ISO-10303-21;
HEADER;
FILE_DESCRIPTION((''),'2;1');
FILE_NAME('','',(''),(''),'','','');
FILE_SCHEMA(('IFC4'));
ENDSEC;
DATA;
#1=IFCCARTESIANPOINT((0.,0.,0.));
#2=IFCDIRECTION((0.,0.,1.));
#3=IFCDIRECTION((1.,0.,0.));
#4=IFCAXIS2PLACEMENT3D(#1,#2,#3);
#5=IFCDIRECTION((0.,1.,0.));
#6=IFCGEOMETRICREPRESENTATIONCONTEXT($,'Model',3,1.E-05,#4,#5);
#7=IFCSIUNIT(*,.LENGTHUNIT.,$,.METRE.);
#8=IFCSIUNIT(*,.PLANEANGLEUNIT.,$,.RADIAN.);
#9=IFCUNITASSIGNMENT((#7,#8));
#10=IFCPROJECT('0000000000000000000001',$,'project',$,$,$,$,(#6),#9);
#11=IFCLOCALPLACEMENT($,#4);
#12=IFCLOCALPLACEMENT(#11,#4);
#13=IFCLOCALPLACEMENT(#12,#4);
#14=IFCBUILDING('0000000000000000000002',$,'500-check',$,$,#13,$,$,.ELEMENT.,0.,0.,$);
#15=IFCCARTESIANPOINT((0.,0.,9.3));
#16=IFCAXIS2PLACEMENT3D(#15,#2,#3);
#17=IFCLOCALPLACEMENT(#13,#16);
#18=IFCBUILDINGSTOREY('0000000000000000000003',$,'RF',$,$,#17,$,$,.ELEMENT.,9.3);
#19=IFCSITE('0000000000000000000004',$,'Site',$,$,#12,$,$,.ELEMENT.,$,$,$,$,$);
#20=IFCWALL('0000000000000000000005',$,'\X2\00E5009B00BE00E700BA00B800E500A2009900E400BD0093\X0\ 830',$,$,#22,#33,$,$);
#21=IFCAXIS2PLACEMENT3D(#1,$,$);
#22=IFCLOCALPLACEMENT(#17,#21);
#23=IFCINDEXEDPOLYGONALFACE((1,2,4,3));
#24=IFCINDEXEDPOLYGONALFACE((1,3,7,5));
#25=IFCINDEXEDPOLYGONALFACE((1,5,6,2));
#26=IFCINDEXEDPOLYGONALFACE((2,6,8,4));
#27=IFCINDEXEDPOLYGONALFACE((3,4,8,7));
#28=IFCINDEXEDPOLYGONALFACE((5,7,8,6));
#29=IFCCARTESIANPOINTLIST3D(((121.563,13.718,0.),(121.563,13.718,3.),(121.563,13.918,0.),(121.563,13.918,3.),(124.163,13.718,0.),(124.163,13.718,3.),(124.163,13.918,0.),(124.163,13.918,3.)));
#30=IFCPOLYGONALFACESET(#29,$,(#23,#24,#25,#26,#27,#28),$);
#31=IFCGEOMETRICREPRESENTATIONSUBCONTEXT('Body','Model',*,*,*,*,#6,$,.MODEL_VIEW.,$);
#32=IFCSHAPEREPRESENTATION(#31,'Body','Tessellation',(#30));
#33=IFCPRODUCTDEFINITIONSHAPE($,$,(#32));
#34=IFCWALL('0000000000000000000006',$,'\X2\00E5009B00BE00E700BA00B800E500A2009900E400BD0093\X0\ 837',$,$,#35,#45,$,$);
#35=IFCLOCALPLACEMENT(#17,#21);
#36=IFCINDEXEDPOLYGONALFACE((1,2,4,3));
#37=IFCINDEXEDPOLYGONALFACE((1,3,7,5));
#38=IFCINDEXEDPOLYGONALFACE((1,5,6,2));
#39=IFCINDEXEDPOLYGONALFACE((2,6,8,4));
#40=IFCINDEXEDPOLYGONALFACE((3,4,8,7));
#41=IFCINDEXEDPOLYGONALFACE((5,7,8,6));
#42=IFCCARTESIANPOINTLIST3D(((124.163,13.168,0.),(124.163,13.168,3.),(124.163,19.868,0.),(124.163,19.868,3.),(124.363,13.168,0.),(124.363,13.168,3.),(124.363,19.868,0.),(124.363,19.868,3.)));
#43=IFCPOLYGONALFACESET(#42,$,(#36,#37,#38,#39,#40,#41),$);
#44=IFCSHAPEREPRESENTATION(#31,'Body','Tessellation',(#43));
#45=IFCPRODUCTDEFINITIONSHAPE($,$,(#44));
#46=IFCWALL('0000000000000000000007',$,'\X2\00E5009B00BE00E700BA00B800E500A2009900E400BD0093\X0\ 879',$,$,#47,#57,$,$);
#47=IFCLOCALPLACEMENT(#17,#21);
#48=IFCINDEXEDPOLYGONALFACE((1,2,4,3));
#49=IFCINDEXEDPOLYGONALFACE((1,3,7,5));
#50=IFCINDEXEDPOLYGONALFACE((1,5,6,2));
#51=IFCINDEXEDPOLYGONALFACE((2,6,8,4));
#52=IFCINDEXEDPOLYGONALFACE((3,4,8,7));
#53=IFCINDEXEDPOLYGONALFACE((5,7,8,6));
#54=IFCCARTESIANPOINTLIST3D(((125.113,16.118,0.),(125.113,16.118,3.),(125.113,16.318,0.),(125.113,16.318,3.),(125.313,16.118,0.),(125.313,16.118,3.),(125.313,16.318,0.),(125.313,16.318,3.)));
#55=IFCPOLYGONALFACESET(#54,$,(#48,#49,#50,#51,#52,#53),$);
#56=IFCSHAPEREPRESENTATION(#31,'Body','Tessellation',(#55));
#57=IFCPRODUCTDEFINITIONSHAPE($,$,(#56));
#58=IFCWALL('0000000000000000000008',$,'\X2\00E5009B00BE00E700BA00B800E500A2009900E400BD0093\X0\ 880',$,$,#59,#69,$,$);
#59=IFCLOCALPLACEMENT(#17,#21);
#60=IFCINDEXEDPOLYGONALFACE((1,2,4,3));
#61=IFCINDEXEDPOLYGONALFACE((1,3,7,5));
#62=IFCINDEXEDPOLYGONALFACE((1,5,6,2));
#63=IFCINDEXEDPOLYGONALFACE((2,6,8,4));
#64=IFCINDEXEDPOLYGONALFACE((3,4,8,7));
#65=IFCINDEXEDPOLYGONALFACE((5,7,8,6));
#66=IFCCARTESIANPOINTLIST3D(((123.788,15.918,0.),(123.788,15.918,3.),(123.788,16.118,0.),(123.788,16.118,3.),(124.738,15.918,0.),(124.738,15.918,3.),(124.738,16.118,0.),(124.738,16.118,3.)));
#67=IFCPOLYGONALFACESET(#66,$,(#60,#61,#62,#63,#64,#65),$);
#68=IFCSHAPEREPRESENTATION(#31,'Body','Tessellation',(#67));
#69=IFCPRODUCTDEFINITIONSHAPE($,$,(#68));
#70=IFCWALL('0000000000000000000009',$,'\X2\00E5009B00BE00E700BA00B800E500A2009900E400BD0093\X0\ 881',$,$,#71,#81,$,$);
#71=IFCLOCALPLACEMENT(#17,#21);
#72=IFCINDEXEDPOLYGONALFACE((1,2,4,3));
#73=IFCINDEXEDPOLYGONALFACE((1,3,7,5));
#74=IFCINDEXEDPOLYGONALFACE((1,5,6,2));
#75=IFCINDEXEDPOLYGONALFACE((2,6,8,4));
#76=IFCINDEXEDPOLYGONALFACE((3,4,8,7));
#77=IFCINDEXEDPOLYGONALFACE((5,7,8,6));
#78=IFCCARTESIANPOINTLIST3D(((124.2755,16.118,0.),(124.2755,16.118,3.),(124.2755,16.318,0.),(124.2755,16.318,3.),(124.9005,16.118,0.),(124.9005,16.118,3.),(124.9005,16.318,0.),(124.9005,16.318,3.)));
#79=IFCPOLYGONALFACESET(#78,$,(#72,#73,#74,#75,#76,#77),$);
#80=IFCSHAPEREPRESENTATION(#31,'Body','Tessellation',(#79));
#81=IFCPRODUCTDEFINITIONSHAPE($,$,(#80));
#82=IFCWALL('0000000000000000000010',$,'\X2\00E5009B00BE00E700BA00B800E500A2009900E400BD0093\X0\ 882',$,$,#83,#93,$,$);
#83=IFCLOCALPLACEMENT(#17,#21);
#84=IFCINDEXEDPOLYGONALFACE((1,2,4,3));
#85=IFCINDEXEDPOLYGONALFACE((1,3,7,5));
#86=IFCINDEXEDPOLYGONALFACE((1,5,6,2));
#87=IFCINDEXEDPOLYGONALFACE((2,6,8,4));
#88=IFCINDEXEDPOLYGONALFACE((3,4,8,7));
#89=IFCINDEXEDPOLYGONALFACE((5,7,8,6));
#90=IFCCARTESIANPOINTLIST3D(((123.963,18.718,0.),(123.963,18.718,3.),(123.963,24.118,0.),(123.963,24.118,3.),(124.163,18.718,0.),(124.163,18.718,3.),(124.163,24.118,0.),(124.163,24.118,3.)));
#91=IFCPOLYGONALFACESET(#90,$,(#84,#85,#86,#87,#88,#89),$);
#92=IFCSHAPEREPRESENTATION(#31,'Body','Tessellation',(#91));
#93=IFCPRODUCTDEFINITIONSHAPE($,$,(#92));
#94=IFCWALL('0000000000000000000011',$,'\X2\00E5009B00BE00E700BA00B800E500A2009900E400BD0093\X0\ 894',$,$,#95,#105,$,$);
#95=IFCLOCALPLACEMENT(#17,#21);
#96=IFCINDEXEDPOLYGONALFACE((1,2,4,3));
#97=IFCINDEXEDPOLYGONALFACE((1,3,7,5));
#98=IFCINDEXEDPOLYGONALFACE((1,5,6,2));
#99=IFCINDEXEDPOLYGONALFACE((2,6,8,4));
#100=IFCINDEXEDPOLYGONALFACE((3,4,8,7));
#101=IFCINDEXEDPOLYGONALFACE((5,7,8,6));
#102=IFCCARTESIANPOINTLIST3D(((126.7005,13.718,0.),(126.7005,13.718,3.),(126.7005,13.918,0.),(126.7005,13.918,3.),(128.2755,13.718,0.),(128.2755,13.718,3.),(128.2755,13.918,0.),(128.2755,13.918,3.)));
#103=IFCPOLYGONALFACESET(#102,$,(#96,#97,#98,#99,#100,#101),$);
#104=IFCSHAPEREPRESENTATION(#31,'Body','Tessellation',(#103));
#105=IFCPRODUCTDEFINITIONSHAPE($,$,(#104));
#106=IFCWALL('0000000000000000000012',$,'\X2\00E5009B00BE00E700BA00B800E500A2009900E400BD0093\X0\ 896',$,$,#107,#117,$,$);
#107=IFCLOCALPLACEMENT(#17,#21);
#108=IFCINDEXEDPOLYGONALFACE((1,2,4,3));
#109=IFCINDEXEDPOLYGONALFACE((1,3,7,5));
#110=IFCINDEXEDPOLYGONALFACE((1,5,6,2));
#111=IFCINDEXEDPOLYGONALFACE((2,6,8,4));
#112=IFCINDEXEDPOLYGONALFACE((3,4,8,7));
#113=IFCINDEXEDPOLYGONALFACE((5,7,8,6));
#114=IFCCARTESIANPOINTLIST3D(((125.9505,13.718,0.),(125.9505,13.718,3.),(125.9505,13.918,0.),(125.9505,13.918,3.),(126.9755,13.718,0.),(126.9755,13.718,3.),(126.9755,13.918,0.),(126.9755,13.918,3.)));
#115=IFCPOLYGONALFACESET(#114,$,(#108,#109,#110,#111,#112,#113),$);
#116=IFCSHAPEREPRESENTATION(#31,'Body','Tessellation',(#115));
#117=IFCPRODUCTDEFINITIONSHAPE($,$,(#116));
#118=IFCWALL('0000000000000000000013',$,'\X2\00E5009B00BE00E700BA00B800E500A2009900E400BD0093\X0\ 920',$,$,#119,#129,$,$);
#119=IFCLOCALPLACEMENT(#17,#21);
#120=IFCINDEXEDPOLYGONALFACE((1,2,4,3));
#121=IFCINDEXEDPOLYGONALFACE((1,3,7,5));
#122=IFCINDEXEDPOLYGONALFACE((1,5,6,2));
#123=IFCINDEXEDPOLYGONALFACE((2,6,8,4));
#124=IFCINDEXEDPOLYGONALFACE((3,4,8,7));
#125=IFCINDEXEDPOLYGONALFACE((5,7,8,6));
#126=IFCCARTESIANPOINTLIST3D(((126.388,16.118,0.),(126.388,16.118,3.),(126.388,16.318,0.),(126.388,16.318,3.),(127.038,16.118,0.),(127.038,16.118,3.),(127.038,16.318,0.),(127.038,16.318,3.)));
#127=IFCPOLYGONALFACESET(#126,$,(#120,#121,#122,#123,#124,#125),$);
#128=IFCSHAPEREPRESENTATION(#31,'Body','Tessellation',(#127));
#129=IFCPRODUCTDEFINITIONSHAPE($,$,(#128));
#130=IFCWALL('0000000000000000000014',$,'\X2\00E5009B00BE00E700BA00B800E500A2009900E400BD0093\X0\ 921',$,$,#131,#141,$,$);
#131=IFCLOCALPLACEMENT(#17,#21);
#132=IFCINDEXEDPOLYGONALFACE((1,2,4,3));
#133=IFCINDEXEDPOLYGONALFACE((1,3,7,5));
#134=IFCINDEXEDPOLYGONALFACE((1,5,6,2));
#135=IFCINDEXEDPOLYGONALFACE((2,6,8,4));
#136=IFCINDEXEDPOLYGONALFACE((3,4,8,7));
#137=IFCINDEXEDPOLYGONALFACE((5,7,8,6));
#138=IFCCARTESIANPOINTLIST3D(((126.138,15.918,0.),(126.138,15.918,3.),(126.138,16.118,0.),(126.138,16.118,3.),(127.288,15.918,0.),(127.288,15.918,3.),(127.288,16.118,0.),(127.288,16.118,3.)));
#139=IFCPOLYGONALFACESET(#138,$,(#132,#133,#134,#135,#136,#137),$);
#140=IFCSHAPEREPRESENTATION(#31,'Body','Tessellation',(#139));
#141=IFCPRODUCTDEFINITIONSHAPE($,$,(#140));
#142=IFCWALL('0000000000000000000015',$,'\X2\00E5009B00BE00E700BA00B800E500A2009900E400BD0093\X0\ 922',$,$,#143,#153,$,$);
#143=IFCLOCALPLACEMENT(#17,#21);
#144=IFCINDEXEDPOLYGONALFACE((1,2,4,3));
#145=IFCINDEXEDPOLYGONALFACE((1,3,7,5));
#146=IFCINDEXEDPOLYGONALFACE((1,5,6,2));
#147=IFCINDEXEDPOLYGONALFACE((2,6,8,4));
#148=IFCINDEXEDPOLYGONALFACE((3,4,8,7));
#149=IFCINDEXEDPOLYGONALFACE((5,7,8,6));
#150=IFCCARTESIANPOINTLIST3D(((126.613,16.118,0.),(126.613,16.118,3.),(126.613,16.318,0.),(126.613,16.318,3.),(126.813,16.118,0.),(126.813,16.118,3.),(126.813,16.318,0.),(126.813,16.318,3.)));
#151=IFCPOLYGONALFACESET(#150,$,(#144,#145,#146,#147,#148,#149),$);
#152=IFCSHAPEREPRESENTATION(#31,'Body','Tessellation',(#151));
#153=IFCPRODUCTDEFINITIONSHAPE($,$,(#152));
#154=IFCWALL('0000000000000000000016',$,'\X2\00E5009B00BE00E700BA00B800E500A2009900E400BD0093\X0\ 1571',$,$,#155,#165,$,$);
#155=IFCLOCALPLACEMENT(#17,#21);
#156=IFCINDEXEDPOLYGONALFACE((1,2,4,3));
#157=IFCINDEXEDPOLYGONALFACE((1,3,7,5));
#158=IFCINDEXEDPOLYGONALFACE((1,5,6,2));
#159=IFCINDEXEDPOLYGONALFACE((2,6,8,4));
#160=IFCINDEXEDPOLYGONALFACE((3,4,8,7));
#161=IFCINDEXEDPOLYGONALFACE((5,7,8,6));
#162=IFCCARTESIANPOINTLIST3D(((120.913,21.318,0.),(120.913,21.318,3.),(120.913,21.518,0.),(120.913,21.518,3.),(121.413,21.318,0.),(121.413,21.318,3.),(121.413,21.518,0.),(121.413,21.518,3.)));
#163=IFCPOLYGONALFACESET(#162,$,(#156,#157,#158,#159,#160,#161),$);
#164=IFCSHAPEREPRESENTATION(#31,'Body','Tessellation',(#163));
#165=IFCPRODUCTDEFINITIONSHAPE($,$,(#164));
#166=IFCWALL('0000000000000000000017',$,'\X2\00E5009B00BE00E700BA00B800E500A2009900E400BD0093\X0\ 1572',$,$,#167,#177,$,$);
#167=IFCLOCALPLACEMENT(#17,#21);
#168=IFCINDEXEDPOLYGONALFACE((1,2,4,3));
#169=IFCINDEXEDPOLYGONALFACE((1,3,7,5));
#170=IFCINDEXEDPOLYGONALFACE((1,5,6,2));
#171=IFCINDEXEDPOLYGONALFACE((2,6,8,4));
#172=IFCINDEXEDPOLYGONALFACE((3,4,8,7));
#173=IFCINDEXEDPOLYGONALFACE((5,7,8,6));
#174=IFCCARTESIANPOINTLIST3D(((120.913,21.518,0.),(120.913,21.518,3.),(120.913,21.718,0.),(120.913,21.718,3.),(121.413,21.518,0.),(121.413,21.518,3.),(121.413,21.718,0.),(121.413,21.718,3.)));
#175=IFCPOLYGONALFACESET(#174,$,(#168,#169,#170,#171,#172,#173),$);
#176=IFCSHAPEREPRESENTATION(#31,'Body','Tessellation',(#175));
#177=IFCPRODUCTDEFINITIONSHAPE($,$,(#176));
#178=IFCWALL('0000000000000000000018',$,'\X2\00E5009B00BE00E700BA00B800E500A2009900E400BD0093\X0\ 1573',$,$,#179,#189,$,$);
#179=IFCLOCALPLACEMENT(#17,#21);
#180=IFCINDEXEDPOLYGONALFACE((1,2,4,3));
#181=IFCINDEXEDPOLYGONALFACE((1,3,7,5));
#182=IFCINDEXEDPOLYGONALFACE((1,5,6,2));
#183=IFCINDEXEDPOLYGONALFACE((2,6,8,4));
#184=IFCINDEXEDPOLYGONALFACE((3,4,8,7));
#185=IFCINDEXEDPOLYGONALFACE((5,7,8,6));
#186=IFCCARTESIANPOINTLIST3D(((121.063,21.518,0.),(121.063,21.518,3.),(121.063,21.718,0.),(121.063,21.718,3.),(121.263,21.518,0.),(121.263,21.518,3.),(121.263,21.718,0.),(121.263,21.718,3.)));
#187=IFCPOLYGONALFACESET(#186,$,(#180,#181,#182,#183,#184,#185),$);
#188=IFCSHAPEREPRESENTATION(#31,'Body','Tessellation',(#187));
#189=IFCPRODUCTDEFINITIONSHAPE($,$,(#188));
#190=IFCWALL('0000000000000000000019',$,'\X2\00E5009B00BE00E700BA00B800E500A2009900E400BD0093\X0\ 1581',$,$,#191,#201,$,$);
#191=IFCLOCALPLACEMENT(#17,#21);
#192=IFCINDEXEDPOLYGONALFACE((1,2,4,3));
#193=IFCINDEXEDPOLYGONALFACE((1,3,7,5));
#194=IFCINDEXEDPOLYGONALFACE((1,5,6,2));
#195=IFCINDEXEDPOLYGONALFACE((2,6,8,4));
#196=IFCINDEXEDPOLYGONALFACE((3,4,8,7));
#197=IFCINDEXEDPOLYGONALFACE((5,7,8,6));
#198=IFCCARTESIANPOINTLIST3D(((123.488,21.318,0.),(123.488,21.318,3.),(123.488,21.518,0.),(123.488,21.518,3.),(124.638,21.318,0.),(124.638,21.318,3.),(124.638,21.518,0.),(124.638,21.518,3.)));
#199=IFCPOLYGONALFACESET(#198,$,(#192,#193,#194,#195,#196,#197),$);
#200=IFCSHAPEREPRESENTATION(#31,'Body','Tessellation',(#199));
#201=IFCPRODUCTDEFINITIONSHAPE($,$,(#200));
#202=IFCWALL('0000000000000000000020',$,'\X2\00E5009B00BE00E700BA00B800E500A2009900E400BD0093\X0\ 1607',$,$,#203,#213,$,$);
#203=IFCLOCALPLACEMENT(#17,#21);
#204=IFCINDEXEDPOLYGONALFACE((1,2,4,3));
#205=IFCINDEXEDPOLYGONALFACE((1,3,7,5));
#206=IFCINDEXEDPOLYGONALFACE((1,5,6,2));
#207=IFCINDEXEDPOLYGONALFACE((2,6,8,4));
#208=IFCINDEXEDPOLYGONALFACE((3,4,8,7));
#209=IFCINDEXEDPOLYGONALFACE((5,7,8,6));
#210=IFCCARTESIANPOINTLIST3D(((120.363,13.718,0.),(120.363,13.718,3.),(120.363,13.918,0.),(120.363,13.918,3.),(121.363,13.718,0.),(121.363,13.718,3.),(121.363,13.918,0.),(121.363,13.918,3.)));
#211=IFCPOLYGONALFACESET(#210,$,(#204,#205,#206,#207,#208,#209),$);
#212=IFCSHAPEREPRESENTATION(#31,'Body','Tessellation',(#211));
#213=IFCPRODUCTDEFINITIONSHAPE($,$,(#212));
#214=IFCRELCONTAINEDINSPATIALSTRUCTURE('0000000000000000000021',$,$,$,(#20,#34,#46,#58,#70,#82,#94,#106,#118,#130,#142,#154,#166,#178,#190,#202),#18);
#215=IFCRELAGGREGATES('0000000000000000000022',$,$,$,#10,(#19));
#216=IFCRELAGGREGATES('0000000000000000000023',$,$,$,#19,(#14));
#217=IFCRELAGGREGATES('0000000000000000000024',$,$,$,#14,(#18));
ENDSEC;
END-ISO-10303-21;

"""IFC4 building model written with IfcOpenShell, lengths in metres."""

from ifc_helpers import new_model, si_unit, direction, frame, frame_2d, origin_with_axes, place, context, subcontext, project, spatial, rectangle, extrude, element, save


model = new_model("IFC4")

# Units and contexts
model_context = context("Model", 3, precision=1e-05, world=origin_with_axes(), true_north=direction((0.0, 1.0, 0.0)))
body_context = subcontext(model_context, "Body", "Model", "MODEL_VIEW")
ifc_project = project(units=[si_unit("LENGTHUNIT", "METRE"), si_unit("PLANEANGLEUNIT", "RADIAN")], contexts=[model_context])

# Site, building, storey
placement = place(None, origin_with_axes())
site_placement = place(placement, origin_with_axes())
site = spatial("IfcSite", under=ifc_project, at=site_placement, Name="Site", CompositionType="ELEMENT")
building_placement = place(site_placement, origin_with_axes())
building = spatial("IfcBuilding", under=site, at=building_placement, Name="500-check", CompositionType="ELEMENT", ElevationOfRefHeight=0.0, ElevationOfTerrain=0.0)
storey_placement = place(building_placement, frame((0.0, 0.0, 9.3), z_axis=(0.0, 0.0, 1.0), x_axis=(1.0, 0.0, 0.0)))
storey = spatial("IfcBuildingStorey", under=building, at=storey_placement, Name="RF", CompositionType="ELEMENT", Elevation=9.3)

# Walls
wall_1_placement = place(storey_placement, frame((122.863, 13.818, 0.0), z_axis=(0.0, 0.0, 1.0), x_axis=(1.0, 0.0, 0.0)))
element("IfcWall", 1, at=wall_1_placement, inside=storey, Name="å\u009b¾çº¸å¢\u0099ä½\u0093 830", context=body_context, shape_type="SweptSolid", body=[
    extrude(rectangle(XDim=2.6, YDim=0.2, at=frame_2d((0.0, 0.0), x_axis=(1.0, 0.0, 0.0))), frame((0.0, 0.0, 0.0), z_axis=(0.0, 0.0, 1.0)), (0.0, 0.0, 1.0), 3.0),
])
wall_2_placement = place(storey_placement, frame((124.263, 16.518, 0.0), z_axis=(0.0, 0.0, 1.0), x_axis=(0.0, 1.0, 0.0)))
element("IfcWall", 2, at=wall_2_placement, inside=storey, Name="å\u009b¾çº¸å¢\u0099ä½\u0093 837", context=body_context, shape_type="SweptSolid", body=[
    extrude(rectangle(XDim=6.7, YDim=0.2, at=frame_2d((0.0, 0.0), x_axis=(1.0, 0.0, 0.0))), frame((0.0, 0.0, 0.0), z_axis=(0.0, 0.0, 1.0)), (0.0, 0.0, 1.0), 3.0),
])
wall_3_placement = place(storey_placement, frame((125.213, 16.218, 0.0), z_axis=(0.0, 0.0, 1.0), x_axis=(0.0, -1.0, 0.0)))
element("IfcWall", 3, at=wall_3_placement, inside=storey, Name="å\u009b¾çº¸å¢\u0099ä½\u0093 879", context=body_context, shape_type="SweptSolid", body=[
    extrude(rectangle(XDim=0.2, YDim=0.2, at=frame_2d((0.0, 0.0), x_axis=(1.0, 0.0, 0.0))), frame((0.0, 0.0, 0.0), z_axis=(0.0, 0.0, 1.0)), (0.0, 0.0, 1.0), 3.0),
])
wall_4_placement = place(storey_placement, frame((124.263, 16.018, 0.0), z_axis=(0.0, 0.0, 1.0), x_axis=(1.0, 0.0, 0.0)))
element("IfcWall", 4, at=wall_4_placement, inside=storey, Name="å\u009b¾çº¸å¢\u0099ä½\u0093 880", context=body_context, shape_type="SweptSolid", body=[
    extrude(rectangle(XDim=0.95, YDim=0.2, at=frame_2d((0.0, 0.0), x_axis=(1.0, 0.0, 0.0))), frame((0.0, 0.0, 0.0), z_axis=(0.0, 0.0, 1.0)), (0.0, 0.0, 1.0), 3.0),
])
wall_5_placement = place(storey_placement, frame((124.588, 16.218, 0.0), z_axis=(0.0, 0.0, 1.0), x_axis=(1.0, 0.0, 0.0)))
element("IfcWall", 5, at=wall_5_placement, inside=storey, Name="å\u009b¾çº¸å¢\u0099ä½\u0093 881", context=body_context, shape_type="SweptSolid", body=[
    extrude(rectangle(XDim=0.625, YDim=0.2, at=frame_2d((0.0, 0.0), x_axis=(1.0, 0.0, 0.0))), frame((0.0, 0.0, 0.0), z_axis=(0.0, 0.0, 1.0)), (0.0, 0.0, 1.0), 3.0),
])
wall_6_placement = place(storey_placement, frame((124.063, 21.418, 0.0), z_axis=(0.0, 0.0, 1.0), x_axis=(0.0, -1.0, 0.0)))
element("IfcWall", 6, at=wall_6_placement, inside=storey, Name="å\u009b¾çº¸å¢\u0099ä½\u0093 882", context=body_context, shape_type="SweptSolid", body=[
    extrude(rectangle(XDim=5.4, YDim=0.2, at=frame_2d((0.0, 0.0), x_axis=(1.0, 0.0, 0.0))), frame((0.0, 0.0, 0.0), z_axis=(0.0, 0.0, 1.0)), (0.0, 0.0, 1.0), 3.0),
])
wall_7_placement = place(storey_placement, frame((127.488, 13.818, 0.0), z_axis=(0.0, 0.0, 1.0), x_axis=(1.0, 0.0, 0.0)))
element("IfcWall", 7, at=wall_7_placement, inside=storey, Name="å\u009b¾çº¸å¢\u0099ä½\u0093 894", context=body_context, shape_type="SweptSolid", body=[
    extrude(rectangle(XDim=1.575, YDim=0.2, at=frame_2d((0.0, 0.0), x_axis=(1.0, 0.0, 0.0))), frame((0.0, 0.0, 0.0), z_axis=(0.0, 0.0, 1.0)), (0.0, 0.0, 1.0), 3.0),
])
wall_8_placement = place(storey_placement, frame((126.463, 13.818, 0.0), z_axis=(0.0, 0.0, 1.0), x_axis=(1.0, 0.0, 0.0)))
element("IfcWall", 8, at=wall_8_placement, inside=storey, Name="å\u009b¾çº¸å¢\u0099ä½\u0093 896", context=body_context, shape_type="SweptSolid", body=[
    extrude(rectangle(XDim=1.025, YDim=0.2, at=frame_2d((0.0, 0.0), x_axis=(1.0, 0.0, 0.0))), frame((0.0, 0.0, 0.0), z_axis=(0.0, 0.0, 1.0)), (0.0, 0.0, 1.0), 3.0),
])
wall_9_placement = place(storey_placement, frame((126.713, 16.218, 0.0), z_axis=(0.0, 0.0, 1.0), x_axis=(1.0, 0.0, 0.0)))
element("IfcWall", 9, at=wall_9_placement, inside=storey, Name="å\u009b¾çº¸å¢\u0099ä½\u0093 920", context=body_context, shape_type="SweptSolid", body=[
    extrude(rectangle(XDim=0.65, YDim=0.2, at=frame_2d((0.0, 0.0), x_axis=(1.0, 0.0, 0.0))), frame((0.0, 0.0, 0.0), z_axis=(0.0, 0.0, 1.0)), (0.0, 0.0, 1.0), 3.0),
])
wall_10_placement = place(storey_placement, frame((126.713, 16.018, 0.0), z_axis=(0.0, 0.0, 1.0), x_axis=(1.0, 0.0, 0.0)))
element("IfcWall", 10, at=wall_10_placement, inside=storey, Name="å\u009b¾çº¸å¢\u0099ä½\u0093 921", context=body_context, shape_type="SweptSolid", body=[
    extrude(rectangle(XDim=1.15, YDim=0.2, at=frame_2d((0.0, 0.0), x_axis=(1.0, 0.0, 0.0))), frame((0.0, 0.0, 0.0), z_axis=(0.0, 0.0, 1.0)), (0.0, 0.0, 1.0), 3.0),
])
wall_11_placement = place(storey_placement, frame((126.713, 16.218, 0.0), z_axis=(0.0, 0.0, 1.0), x_axis=(0.0, -1.0, 0.0)))
element("IfcWall", 11, at=wall_11_placement, inside=storey, Name="å\u009b¾çº¸å¢\u0099ä½\u0093 922", context=body_context, shape_type="SweptSolid", body=[
    extrude(rectangle(XDim=0.2, YDim=0.2, at=frame_2d((0.0, 0.0), x_axis=(1.0, 0.0, 0.0))), frame((0.0, 0.0, 0.0), z_axis=(0.0, 0.0, 1.0)), (0.0, 0.0, 1.0), 3.0),
])
for number, where, z_axis, x_axis, name in (
    (12, (121.163, 21.418, 0.0), (0.0, 0.0, 1.0), (-1.0, 0.0, 0.0), "å\u009b¾çº¸å¢\u0099ä½\u0093 1571"),
    (13, (121.163, 21.618, 0.0), (0.0, 0.0, 1.0), (-1.0, 0.0, 0.0), "å\u009b¾çº¸å¢\u0099ä½\u0093 1572"),
):
    element("IfcWall", number, at=place(storey_placement, frame(where, z_axis=z_axis, x_axis=x_axis)), inside=storey, Name=name, context=body_context, shape_type="SweptSolid", body=[
        extrude(rectangle(XDim=0.5, YDim=0.2, at=frame_2d((0.0, 0.0), x_axis=(1.0, 0.0, 0.0))), frame((0.0, 0.0, 0.0), z_axis=(0.0, 0.0, 1.0)), (0.0, 0.0, 1.0), 3.0),
    ])
wall_12_placement = place(storey_placement, frame((121.163, 21.618, 0.0), z_axis=(0.0, 0.0, 1.0), x_axis=(0.0, -1.0, 0.0)))
element("IfcWall", 14, at=wall_12_placement, inside=storey, Name="å\u009b¾çº¸å¢\u0099ä½\u0093 1573", context=body_context, shape_type="SweptSolid", body=[
    extrude(rectangle(XDim=0.2, YDim=0.2, at=frame_2d((0.0, 0.0), x_axis=(1.0, 0.0, 0.0))), frame((0.0, 0.0, 0.0), z_axis=(0.0, 0.0, 1.0)), (0.0, 0.0, 1.0), 3.0),
])
wall_13_placement = place(storey_placement, frame((124.063, 21.418, 0.0), z_axis=(0.0, 0.0, 1.0), x_axis=(-1.0, 0.0, 0.0)))
element("IfcWall", 15, at=wall_13_placement, inside=storey, Name="å\u009b¾çº¸å¢\u0099ä½\u0093 1581", context=body_context, shape_type="SweptSolid", body=[
    extrude(rectangle(XDim=1.15, YDim=0.2, at=frame_2d((0.0, 0.0), x_axis=(1.0, 0.0, 0.0))), frame((0.0, 0.0, 0.0), z_axis=(0.0, 0.0, 1.0)), (0.0, 0.0, 1.0), 3.0),
])
wall_14_placement = place(storey_placement, frame((120.863, 13.818, 0.0), z_axis=(0.0, 0.0, 1.0), x_axis=(1.0, 0.0, 0.0)))
element("IfcWall", 16, at=wall_14_placement, inside=storey, Name="å\u009b¾çº¸å¢\u0099ä½\u0093 1607", context=body_context, shape_type="SweptSolid", body=[
    extrude(rectangle(XDim=1.0, YDim=0.2, at=frame_2d((0.0, 0.0), x_axis=(1.0, 0.0, 0.0))), frame((0.0, 0.0, 0.0), z_axis=(0.0, 0.0, 1.0)), (0.0, 0.0, 1.0), 3.0),
])

save(model, "model.ifc")
